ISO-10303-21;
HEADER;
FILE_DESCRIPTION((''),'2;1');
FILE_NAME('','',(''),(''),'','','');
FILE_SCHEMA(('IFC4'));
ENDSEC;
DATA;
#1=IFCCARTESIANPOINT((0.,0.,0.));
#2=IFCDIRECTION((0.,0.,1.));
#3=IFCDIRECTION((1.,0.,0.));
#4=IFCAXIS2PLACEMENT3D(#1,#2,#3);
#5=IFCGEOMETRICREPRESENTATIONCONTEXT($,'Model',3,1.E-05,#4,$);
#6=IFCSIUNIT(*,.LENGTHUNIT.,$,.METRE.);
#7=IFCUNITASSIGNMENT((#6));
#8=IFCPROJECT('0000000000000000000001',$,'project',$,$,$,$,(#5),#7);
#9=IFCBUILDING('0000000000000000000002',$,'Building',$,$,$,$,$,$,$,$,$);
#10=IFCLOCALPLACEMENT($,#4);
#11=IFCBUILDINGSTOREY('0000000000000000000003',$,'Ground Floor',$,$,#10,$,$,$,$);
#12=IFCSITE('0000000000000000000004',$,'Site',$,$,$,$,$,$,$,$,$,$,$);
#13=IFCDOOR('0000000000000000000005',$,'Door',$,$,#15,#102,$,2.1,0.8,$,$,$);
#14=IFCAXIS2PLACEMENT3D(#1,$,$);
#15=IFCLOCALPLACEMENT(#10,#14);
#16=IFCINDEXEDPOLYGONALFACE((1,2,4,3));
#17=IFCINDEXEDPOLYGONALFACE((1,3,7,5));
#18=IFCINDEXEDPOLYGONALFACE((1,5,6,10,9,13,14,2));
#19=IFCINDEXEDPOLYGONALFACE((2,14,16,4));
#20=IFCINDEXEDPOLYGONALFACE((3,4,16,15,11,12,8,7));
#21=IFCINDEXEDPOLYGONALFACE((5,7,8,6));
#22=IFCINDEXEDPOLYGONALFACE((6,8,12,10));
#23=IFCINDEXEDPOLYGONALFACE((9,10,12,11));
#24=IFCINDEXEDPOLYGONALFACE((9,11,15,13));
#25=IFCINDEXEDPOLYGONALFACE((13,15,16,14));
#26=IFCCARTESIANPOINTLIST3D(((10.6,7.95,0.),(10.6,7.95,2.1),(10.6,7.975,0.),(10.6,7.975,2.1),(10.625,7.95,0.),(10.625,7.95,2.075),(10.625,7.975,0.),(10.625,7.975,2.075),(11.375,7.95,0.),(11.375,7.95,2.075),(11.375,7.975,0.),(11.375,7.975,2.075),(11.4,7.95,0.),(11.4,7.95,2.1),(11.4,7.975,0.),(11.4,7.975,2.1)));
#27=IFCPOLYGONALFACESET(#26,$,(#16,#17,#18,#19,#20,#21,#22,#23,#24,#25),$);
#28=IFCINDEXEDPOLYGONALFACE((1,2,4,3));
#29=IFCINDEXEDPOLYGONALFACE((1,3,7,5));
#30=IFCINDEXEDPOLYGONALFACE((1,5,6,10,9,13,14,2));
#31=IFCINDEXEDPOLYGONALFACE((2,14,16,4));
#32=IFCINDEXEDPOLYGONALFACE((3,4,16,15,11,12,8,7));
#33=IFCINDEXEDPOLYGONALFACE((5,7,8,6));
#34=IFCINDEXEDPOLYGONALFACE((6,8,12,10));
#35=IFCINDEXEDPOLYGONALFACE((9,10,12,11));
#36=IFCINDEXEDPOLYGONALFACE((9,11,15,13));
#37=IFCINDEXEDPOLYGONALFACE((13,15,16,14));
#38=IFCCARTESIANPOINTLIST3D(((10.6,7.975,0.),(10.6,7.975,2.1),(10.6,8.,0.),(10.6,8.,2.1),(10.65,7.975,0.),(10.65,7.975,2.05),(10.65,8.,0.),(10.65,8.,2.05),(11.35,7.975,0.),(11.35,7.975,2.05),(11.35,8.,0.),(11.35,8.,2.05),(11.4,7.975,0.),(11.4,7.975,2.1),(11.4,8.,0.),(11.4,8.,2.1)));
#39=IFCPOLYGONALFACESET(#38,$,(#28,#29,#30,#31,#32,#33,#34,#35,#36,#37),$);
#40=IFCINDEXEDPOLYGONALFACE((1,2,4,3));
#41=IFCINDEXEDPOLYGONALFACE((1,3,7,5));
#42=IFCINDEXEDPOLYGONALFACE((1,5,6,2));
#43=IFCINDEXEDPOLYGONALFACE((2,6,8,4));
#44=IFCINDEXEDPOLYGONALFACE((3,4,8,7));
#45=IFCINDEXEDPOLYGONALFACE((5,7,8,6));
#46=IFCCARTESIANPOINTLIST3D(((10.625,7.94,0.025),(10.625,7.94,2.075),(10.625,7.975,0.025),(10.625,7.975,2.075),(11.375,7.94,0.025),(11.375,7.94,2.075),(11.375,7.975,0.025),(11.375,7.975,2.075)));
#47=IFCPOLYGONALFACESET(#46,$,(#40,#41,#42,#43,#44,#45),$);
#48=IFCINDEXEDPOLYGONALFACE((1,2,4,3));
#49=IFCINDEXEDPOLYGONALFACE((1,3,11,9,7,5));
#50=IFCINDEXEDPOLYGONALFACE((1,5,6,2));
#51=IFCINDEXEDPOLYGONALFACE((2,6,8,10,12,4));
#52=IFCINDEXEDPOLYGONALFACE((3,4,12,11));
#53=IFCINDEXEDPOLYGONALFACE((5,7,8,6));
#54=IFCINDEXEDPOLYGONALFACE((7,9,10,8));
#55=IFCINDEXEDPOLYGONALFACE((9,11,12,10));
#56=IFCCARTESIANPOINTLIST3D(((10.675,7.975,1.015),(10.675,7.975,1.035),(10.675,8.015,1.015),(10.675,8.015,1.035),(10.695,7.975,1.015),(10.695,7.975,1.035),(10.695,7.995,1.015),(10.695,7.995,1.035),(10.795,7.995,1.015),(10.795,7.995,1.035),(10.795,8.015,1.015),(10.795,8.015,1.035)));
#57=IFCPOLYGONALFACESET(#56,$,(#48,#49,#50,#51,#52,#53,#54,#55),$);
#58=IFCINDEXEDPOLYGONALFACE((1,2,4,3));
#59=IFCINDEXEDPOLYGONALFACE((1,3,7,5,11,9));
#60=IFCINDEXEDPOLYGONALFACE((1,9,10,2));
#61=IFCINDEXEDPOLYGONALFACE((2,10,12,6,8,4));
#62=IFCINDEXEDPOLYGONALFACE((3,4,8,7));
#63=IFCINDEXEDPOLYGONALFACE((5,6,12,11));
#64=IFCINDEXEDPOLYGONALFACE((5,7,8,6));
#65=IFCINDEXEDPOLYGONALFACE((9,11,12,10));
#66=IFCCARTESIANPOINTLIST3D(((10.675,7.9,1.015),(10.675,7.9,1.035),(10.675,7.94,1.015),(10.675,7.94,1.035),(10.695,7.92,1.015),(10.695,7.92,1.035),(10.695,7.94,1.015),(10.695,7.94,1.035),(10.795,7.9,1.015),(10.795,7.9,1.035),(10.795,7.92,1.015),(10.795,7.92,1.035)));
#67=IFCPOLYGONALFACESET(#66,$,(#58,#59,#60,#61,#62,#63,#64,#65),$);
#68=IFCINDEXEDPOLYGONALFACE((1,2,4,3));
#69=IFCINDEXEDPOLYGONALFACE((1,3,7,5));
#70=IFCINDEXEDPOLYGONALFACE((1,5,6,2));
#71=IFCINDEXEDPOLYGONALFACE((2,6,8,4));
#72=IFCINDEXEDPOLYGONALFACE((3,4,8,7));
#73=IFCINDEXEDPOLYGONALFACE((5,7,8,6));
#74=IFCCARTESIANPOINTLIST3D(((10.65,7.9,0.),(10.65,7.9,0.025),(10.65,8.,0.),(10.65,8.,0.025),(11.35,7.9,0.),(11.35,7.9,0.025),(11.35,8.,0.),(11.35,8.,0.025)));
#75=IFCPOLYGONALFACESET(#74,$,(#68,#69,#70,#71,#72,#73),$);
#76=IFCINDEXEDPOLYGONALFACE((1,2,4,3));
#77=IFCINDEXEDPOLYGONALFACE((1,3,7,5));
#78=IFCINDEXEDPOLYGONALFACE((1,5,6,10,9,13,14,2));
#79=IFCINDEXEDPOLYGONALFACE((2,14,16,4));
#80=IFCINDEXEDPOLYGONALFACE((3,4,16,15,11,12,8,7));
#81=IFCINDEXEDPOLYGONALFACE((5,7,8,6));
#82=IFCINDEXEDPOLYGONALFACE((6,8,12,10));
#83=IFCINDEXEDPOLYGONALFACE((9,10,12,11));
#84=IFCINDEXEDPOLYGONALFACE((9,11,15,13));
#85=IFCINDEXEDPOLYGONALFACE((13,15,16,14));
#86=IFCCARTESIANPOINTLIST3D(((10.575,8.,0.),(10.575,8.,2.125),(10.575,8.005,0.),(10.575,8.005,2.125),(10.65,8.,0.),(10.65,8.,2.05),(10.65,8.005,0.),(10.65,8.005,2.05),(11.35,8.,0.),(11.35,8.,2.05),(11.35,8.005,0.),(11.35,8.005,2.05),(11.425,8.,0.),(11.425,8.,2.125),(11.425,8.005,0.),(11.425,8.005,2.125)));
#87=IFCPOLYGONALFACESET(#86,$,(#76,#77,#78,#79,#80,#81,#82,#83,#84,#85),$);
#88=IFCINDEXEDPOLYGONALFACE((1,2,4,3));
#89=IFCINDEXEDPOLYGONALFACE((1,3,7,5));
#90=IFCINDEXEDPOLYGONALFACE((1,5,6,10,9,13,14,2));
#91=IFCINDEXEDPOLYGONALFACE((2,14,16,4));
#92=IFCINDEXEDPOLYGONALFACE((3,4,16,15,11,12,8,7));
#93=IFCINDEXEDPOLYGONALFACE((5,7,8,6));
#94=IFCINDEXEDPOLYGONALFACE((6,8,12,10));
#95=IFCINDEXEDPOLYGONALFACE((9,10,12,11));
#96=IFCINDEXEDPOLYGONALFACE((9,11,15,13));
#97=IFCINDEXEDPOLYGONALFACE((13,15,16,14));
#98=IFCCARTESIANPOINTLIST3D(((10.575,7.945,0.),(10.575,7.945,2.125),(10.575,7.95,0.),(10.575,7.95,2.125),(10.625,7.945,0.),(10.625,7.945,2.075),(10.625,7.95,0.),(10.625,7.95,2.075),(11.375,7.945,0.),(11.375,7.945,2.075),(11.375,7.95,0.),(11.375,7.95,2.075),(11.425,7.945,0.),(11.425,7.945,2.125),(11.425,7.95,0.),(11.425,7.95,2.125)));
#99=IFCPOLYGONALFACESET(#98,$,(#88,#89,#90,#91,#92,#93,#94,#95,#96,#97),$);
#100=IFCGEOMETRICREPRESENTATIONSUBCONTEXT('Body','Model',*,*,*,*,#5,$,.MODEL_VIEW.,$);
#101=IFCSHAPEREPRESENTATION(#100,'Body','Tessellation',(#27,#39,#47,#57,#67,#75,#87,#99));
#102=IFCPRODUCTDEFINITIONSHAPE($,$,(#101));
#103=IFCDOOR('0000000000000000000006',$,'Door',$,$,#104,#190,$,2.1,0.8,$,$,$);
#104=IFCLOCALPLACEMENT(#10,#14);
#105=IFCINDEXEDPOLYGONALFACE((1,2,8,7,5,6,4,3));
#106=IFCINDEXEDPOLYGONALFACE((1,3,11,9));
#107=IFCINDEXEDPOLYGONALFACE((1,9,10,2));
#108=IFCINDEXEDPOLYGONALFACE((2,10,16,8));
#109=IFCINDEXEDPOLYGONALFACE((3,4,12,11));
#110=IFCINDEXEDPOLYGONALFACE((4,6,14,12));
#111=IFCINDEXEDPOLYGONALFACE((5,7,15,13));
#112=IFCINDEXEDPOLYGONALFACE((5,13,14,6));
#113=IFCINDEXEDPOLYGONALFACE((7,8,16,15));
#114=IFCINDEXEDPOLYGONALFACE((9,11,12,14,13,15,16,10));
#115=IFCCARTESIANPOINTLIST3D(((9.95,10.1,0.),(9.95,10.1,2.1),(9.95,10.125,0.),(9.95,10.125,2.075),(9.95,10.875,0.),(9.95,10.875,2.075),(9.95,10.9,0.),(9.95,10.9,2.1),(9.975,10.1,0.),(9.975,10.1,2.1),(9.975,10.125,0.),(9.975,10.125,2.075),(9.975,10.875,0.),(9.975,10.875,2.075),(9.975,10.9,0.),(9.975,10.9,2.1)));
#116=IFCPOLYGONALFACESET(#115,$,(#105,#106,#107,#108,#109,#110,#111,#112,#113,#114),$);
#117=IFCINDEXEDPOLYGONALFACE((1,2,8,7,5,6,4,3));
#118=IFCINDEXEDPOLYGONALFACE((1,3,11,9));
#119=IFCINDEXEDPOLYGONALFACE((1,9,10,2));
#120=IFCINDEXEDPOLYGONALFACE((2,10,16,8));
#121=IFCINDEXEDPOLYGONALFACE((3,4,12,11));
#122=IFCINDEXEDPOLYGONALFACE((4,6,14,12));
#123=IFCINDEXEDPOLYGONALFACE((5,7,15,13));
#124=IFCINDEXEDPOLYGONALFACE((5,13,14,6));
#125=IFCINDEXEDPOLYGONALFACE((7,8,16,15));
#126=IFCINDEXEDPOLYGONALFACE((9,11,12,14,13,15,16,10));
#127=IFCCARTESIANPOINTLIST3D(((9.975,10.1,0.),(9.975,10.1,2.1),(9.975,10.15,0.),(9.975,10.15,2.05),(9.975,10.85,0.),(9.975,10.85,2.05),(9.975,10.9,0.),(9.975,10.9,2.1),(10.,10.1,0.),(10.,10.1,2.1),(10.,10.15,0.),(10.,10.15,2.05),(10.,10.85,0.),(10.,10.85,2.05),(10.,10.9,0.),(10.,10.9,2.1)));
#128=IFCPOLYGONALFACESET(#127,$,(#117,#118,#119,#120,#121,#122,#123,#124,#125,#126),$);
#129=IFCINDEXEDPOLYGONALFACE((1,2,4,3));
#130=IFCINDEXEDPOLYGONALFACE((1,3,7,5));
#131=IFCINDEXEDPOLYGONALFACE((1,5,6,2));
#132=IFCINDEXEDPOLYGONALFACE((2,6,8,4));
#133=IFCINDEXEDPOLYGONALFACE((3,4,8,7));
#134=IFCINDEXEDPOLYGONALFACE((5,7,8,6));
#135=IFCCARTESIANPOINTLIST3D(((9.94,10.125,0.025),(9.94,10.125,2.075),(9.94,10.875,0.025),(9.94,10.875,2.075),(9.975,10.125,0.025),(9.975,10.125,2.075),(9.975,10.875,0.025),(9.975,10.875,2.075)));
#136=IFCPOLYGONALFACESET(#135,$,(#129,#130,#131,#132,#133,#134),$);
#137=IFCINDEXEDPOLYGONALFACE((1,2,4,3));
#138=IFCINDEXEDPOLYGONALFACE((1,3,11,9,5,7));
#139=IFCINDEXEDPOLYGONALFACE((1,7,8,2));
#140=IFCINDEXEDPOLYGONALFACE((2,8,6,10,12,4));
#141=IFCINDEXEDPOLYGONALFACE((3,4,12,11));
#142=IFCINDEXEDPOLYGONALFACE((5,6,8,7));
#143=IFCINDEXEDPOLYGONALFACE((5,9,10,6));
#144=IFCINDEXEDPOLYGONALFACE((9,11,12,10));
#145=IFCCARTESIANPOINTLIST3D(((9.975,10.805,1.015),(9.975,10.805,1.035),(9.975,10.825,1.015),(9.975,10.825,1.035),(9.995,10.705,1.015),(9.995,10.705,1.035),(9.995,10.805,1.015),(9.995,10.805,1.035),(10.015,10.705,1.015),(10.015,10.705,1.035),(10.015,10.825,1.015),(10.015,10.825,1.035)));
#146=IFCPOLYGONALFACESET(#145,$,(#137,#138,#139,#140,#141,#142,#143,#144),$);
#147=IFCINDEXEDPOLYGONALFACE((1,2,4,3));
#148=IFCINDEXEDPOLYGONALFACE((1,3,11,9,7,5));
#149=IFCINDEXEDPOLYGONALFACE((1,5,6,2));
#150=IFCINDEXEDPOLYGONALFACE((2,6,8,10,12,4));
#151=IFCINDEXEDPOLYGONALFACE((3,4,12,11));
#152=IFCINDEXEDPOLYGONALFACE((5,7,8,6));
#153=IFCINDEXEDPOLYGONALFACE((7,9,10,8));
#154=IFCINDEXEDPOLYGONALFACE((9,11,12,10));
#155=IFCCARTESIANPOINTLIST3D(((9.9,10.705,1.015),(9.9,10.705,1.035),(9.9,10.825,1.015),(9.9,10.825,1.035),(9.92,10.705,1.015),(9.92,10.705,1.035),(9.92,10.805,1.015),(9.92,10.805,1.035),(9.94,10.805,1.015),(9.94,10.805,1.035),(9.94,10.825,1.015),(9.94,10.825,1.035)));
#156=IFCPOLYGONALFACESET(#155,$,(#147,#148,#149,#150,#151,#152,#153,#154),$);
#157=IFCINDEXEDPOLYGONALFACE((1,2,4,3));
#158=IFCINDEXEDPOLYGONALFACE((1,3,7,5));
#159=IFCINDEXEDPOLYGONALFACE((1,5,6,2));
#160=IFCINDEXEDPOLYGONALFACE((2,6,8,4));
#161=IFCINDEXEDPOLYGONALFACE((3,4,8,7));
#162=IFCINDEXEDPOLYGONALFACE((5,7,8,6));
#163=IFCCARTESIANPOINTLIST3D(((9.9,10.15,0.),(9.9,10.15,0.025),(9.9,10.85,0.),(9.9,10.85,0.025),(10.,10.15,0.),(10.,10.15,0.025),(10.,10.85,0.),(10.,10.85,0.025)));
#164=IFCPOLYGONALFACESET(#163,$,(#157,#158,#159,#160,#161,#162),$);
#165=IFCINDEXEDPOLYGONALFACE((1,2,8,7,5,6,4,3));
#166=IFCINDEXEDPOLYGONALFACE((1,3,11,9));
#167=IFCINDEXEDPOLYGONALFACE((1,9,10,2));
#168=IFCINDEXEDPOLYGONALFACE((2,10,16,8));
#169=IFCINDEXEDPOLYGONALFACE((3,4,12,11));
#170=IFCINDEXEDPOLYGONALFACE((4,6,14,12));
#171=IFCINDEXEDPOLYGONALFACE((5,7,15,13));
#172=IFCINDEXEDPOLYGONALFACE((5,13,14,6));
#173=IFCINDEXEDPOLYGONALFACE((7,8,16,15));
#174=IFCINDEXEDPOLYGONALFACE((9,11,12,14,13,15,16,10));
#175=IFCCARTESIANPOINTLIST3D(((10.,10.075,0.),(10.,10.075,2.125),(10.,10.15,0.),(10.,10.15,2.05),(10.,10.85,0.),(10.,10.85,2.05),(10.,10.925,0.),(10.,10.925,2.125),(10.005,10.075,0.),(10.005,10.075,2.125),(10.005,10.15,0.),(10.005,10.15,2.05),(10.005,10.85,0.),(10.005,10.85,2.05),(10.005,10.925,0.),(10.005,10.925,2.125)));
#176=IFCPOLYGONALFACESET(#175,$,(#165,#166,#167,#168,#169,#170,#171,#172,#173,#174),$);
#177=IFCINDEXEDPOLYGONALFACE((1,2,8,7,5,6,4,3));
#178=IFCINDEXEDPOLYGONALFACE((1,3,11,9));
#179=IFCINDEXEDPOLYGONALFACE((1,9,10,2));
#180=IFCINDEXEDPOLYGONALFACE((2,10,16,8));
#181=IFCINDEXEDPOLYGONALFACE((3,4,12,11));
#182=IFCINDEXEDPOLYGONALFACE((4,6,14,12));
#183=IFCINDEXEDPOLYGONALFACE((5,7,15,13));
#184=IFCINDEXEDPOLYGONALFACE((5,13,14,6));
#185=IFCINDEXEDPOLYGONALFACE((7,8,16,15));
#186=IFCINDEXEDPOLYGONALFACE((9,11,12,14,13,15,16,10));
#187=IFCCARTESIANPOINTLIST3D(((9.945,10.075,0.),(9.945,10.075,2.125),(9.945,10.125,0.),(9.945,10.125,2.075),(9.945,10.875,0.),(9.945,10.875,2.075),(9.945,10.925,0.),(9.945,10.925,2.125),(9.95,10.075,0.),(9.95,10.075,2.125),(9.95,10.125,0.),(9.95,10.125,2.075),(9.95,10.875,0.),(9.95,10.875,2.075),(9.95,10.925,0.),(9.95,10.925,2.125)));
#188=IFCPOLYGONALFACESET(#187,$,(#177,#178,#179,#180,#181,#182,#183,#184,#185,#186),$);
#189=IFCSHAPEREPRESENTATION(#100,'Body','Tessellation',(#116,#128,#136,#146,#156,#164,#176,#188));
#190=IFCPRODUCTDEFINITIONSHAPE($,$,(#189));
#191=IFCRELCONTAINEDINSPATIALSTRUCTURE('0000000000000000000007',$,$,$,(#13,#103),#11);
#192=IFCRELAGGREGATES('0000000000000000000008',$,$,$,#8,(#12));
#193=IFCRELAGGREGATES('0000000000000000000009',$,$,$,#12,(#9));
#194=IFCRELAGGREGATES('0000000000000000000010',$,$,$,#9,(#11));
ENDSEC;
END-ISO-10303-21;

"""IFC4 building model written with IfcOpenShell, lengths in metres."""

from ifc_helpers import new_model, si_unit, frame, origin_with_axes, place, context, subcontext, project, spatial, line, indexed_curve, outline, extrude, element, save


model = new_model("IFC4")

# Units and contexts
model_context = context("Model", 3, precision=1e-05, world=origin_with_axes())
body_context = subcontext(model_context, "Body", "Model", "MODEL_VIEW")
ifc_project = project(units=[si_unit("LENGTHUNIT", "METRE")], contexts=[model_context])

# Site, building, storey
site = spatial("IfcSite", under=ifc_project, Name="Site")
building = spatial("IfcBuilding", under=site, Name="Building")
storey_placement = place(None, origin_with_axes())
storey = spatial("IfcBuildingStorey", under=building, at=storey_placement, Name="Ground Floor")

# Doors
door_1_placement = place(storey_placement, frame((11.4, 8.0, 0.0), z_axis=(0.0, 0.0, 1.0), x_axis=(-1.0, 0.0, 0.0)))
element("IfcDoor", 1, at=door_1_placement, inside=storey, Name="Door", OverallHeight=2.1, OverallWidth=0.8, context=body_context, shape_type="SweptSolid", body=[
    extrude(outline(indexed_curve([(0.0, 0.0), (0.0, 2.1), (0.8, 2.1), (0.8, 0.0), (0.775, 0.0), (0.775, 2.075), (0.025, 2.075), (0.025, 0.0)], segments=[line(1, 2, 3, 4, 5, 6, 7, 8, 1)])), frame((0.0, 0.025, 0.0), z_axis=(0.0, -1.0, 0.0), x_axis=(1.0, 0.0, 0.0)), (0.0, 0.0, -1.0), 0.025),
    extrude(outline(indexed_curve([(0.0, 0.0), (0.0, 2.1), (0.8, 2.1), (0.8, 0.0), (0.75, 0.0), (0.75, 2.05), (0.05, 2.05), (0.05, 0.0)], segments=[line(1, 2, 3, 4, 5, 6, 7, 8, 1)])), frame((0.0, 0.0, 0.0), z_axis=(0.0, -1.0, 0.0), x_axis=(1.0, 0.0, 0.0)), (0.0, 0.0, -1.0), 0.025),
    extrude(outline(indexed_curve([(0.0, 0.0), (0.75, 0.0), (0.75, 0.035), (0.0, 0.035)], segments=[line(1, 2, 3, 4, 1)])), frame((0.025, 0.025, 0.025), z_axis=(0.0, 0.0, 1.0), x_axis=(1.0, 0.0, 0.0)), (0.0, 0.0, 1.0), 2.05),
    extrude(outline(indexed_curve([(0.0, 0.0), (0.0, -0.04), (-0.12, -0.04), (-0.12, -0.02), (-0.02, -0.02), (-0.02, 0.0)], segments=[line(1, 2, 3, 4, 5, 6, 1)])), frame((0.725, 0.025, 1.015), z_axis=(0.0, 0.0, 1.0), x_axis=(1.0, 0.0, 0.0)), (0.0, 0.0, 1.0), 0.02),
    extrude(outline(indexed_curve([(0.0, 0.0), (0.0, 0.04), (-0.12, 0.04), (-0.12, 0.02), (-0.02, 0.02), (-0.02, 0.0)], segments=[line(1, 2, 3, 4, 5, 6, 1)])), frame((0.725, 0.06, 1.015), z_axis=(0.0, 0.0, 1.0), x_axis=(1.0, 0.0, 0.0)), (0.0, 0.0, 1.0), 0.02),
    extrude(outline(indexed_curve([(0.0, 0.0), (0.7, 0.0), (0.7, 0.1), (0.0, 0.1)], segments=[line(1, 2, 3, 4, 1)])), frame((0.05, 0.0, 0.0), z_axis=(0.0, 0.0, 1.0), x_axis=(1.0, 0.0, 0.0)), (0.0, 0.0, 1.0), 0.025),
    extrude(outline(indexed_curve([(0.0, 0.0), (0.0, 2.125), (0.85, 2.125), (0.85, 0.0), (0.775, 0.0), (0.775, 2.05), (0.075, 2.05), (0.075, 0.0)], segments=[line(1, 2, 3, 4, 5, 6, 7, 8, 1)])), frame((-0.025, -0.005, 0.0), z_axis=(0.0, -1.0, 0.0), x_axis=(1.0, 0.0, 0.0)), (0.0, 0.0, -1.0), 0.005),
    extrude(outline(indexed_curve([(0.0, 0.0), (0.0, 2.125), (0.85, 2.125), (0.85, 0.0), (0.8, 0.0), (0.8, 2.075), (0.05, 2.075), (0.05, 0.0)], segments=[line(1, 2, 3, 4, 5, 6, 7, 8, 1)])), frame((-0.025, 0.05, 0.0), z_axis=(0.0, -1.0, 0.0), x_axis=(1.0, 0.0, 0.0)), (0.0, 0.0, -1.0), 0.005),
])
door_2_placement = place(storey_placement, frame((10.0, 10.1, 0.0), z_axis=(0.0, 0.0, 1.0), x_axis=(0.0, 1.0, 0.0)))
element("IfcDoor", 2, at=door_2_placement, inside=storey, Name="Door", OverallHeight=2.1, OverallWidth=0.8, context=body_context, shape_type="SweptSolid", body=[
    extrude(outline(indexed_curve([(0.0, 0.0), (0.0, 2.1), (0.8, 2.1), (0.8, 0.0), (0.775, 0.0), (0.775, 2.075), (0.025, 2.075), (0.025, 0.0)], segments=[line(1, 2, 3, 4, 5, 6, 7, 8, 1)])), frame((0.0, 0.025, 0.0), z_axis=(0.0, -1.0, 0.0), x_axis=(1.0, 0.0, 0.0)), (0.0, 0.0, -1.0), 0.025),
    extrude(outline(indexed_curve([(0.0, 0.0), (0.0, 2.1), (0.8, 2.1), (0.8, 0.0), (0.75, 0.0), (0.75, 2.05), (0.05, 2.05), (0.05, 0.0)], segments=[line(1, 2, 3, 4, 5, 6, 7, 8, 1)])), frame((0.0, 0.0, 0.0), z_axis=(0.0, -1.0, 0.0), x_axis=(1.0, 0.0, 0.0)), (0.0, 0.0, -1.0), 0.025),
    extrude(outline(indexed_curve([(0.0, 0.0), (0.75, 0.0), (0.75, 0.035), (0.0, 0.035)], segments=[line(1, 2, 3, 4, 1)])), frame((0.025, 0.025, 0.025), z_axis=(0.0, 0.0, 1.0), x_axis=(1.0, 0.0, 0.0)), (0.0, 0.0, 1.0), 2.05),
    extrude(outline(indexed_curve([(0.0, 0.0), (0.0, -0.04), (-0.12, -0.04), (-0.12, -0.02), (-0.02, -0.02), (-0.02, 0.0)], segments=[line(1, 2, 3, 4, 5, 6, 1)])), frame((0.725, 0.025, 1.015), z_axis=(0.0, 0.0, 1.0), x_axis=(1.0, 0.0, 0.0)), (0.0, 0.0, 1.0), 0.02),
    extrude(outline(indexed_curve([(0.0, 0.0), (0.0, 0.04), (-0.12, 0.04), (-0.12, 0.02), (-0.02, 0.02), (-0.02, 0.0)], segments=[line(1, 2, 3, 4, 5, 6, 1)])), frame((0.725, 0.06, 1.015), z_axis=(0.0, 0.0, 1.0), x_axis=(1.0, 0.0, 0.0)), (0.0, 0.0, 1.0), 0.02),
    extrude(outline(indexed_curve([(0.0, 0.0), (0.7, 0.0), (0.7, 0.1), (0.0, 0.1)], segments=[line(1, 2, 3, 4, 1)])), frame((0.05, 0.0, 0.0), z_axis=(0.0, 0.0, 1.0), x_axis=(1.0, 0.0, 0.0)), (0.0, 0.0, 1.0), 0.025),
    extrude(outline(indexed_curve([(0.0, 0.0), (0.0, 2.125), (0.85, 2.125), (0.85, 0.0), (0.775, 0.0), (0.775, 2.05), (0.075, 2.05), (0.075, 0.0)], segments=[line(1, 2, 3, 4, 5, 6, 7, 8, 1)])), frame((-0.025, -0.005, 0.0), z_axis=(0.0, -1.0, 0.0), x_axis=(1.0, 0.0, 0.0)), (0.0, 0.0, -1.0), 0.005),
    extrude(outline(indexed_curve([(0.0, 0.0), (0.0, 2.125), (0.85, 2.125), (0.85, 0.0), (0.8, 0.0), (0.8, 2.075), (0.05, 2.075), (0.05, 0.0)], segments=[line(1, 2, 3, 4, 5, 6, 7, 8, 1)])), frame((-0.025, 0.05, 0.0), z_axis=(0.0, -1.0, 0.0), x_axis=(1.0, 0.0, 0.0)), (0.0, 0.0, -1.0), 0.005),
])

save(model, "model.ifc")
